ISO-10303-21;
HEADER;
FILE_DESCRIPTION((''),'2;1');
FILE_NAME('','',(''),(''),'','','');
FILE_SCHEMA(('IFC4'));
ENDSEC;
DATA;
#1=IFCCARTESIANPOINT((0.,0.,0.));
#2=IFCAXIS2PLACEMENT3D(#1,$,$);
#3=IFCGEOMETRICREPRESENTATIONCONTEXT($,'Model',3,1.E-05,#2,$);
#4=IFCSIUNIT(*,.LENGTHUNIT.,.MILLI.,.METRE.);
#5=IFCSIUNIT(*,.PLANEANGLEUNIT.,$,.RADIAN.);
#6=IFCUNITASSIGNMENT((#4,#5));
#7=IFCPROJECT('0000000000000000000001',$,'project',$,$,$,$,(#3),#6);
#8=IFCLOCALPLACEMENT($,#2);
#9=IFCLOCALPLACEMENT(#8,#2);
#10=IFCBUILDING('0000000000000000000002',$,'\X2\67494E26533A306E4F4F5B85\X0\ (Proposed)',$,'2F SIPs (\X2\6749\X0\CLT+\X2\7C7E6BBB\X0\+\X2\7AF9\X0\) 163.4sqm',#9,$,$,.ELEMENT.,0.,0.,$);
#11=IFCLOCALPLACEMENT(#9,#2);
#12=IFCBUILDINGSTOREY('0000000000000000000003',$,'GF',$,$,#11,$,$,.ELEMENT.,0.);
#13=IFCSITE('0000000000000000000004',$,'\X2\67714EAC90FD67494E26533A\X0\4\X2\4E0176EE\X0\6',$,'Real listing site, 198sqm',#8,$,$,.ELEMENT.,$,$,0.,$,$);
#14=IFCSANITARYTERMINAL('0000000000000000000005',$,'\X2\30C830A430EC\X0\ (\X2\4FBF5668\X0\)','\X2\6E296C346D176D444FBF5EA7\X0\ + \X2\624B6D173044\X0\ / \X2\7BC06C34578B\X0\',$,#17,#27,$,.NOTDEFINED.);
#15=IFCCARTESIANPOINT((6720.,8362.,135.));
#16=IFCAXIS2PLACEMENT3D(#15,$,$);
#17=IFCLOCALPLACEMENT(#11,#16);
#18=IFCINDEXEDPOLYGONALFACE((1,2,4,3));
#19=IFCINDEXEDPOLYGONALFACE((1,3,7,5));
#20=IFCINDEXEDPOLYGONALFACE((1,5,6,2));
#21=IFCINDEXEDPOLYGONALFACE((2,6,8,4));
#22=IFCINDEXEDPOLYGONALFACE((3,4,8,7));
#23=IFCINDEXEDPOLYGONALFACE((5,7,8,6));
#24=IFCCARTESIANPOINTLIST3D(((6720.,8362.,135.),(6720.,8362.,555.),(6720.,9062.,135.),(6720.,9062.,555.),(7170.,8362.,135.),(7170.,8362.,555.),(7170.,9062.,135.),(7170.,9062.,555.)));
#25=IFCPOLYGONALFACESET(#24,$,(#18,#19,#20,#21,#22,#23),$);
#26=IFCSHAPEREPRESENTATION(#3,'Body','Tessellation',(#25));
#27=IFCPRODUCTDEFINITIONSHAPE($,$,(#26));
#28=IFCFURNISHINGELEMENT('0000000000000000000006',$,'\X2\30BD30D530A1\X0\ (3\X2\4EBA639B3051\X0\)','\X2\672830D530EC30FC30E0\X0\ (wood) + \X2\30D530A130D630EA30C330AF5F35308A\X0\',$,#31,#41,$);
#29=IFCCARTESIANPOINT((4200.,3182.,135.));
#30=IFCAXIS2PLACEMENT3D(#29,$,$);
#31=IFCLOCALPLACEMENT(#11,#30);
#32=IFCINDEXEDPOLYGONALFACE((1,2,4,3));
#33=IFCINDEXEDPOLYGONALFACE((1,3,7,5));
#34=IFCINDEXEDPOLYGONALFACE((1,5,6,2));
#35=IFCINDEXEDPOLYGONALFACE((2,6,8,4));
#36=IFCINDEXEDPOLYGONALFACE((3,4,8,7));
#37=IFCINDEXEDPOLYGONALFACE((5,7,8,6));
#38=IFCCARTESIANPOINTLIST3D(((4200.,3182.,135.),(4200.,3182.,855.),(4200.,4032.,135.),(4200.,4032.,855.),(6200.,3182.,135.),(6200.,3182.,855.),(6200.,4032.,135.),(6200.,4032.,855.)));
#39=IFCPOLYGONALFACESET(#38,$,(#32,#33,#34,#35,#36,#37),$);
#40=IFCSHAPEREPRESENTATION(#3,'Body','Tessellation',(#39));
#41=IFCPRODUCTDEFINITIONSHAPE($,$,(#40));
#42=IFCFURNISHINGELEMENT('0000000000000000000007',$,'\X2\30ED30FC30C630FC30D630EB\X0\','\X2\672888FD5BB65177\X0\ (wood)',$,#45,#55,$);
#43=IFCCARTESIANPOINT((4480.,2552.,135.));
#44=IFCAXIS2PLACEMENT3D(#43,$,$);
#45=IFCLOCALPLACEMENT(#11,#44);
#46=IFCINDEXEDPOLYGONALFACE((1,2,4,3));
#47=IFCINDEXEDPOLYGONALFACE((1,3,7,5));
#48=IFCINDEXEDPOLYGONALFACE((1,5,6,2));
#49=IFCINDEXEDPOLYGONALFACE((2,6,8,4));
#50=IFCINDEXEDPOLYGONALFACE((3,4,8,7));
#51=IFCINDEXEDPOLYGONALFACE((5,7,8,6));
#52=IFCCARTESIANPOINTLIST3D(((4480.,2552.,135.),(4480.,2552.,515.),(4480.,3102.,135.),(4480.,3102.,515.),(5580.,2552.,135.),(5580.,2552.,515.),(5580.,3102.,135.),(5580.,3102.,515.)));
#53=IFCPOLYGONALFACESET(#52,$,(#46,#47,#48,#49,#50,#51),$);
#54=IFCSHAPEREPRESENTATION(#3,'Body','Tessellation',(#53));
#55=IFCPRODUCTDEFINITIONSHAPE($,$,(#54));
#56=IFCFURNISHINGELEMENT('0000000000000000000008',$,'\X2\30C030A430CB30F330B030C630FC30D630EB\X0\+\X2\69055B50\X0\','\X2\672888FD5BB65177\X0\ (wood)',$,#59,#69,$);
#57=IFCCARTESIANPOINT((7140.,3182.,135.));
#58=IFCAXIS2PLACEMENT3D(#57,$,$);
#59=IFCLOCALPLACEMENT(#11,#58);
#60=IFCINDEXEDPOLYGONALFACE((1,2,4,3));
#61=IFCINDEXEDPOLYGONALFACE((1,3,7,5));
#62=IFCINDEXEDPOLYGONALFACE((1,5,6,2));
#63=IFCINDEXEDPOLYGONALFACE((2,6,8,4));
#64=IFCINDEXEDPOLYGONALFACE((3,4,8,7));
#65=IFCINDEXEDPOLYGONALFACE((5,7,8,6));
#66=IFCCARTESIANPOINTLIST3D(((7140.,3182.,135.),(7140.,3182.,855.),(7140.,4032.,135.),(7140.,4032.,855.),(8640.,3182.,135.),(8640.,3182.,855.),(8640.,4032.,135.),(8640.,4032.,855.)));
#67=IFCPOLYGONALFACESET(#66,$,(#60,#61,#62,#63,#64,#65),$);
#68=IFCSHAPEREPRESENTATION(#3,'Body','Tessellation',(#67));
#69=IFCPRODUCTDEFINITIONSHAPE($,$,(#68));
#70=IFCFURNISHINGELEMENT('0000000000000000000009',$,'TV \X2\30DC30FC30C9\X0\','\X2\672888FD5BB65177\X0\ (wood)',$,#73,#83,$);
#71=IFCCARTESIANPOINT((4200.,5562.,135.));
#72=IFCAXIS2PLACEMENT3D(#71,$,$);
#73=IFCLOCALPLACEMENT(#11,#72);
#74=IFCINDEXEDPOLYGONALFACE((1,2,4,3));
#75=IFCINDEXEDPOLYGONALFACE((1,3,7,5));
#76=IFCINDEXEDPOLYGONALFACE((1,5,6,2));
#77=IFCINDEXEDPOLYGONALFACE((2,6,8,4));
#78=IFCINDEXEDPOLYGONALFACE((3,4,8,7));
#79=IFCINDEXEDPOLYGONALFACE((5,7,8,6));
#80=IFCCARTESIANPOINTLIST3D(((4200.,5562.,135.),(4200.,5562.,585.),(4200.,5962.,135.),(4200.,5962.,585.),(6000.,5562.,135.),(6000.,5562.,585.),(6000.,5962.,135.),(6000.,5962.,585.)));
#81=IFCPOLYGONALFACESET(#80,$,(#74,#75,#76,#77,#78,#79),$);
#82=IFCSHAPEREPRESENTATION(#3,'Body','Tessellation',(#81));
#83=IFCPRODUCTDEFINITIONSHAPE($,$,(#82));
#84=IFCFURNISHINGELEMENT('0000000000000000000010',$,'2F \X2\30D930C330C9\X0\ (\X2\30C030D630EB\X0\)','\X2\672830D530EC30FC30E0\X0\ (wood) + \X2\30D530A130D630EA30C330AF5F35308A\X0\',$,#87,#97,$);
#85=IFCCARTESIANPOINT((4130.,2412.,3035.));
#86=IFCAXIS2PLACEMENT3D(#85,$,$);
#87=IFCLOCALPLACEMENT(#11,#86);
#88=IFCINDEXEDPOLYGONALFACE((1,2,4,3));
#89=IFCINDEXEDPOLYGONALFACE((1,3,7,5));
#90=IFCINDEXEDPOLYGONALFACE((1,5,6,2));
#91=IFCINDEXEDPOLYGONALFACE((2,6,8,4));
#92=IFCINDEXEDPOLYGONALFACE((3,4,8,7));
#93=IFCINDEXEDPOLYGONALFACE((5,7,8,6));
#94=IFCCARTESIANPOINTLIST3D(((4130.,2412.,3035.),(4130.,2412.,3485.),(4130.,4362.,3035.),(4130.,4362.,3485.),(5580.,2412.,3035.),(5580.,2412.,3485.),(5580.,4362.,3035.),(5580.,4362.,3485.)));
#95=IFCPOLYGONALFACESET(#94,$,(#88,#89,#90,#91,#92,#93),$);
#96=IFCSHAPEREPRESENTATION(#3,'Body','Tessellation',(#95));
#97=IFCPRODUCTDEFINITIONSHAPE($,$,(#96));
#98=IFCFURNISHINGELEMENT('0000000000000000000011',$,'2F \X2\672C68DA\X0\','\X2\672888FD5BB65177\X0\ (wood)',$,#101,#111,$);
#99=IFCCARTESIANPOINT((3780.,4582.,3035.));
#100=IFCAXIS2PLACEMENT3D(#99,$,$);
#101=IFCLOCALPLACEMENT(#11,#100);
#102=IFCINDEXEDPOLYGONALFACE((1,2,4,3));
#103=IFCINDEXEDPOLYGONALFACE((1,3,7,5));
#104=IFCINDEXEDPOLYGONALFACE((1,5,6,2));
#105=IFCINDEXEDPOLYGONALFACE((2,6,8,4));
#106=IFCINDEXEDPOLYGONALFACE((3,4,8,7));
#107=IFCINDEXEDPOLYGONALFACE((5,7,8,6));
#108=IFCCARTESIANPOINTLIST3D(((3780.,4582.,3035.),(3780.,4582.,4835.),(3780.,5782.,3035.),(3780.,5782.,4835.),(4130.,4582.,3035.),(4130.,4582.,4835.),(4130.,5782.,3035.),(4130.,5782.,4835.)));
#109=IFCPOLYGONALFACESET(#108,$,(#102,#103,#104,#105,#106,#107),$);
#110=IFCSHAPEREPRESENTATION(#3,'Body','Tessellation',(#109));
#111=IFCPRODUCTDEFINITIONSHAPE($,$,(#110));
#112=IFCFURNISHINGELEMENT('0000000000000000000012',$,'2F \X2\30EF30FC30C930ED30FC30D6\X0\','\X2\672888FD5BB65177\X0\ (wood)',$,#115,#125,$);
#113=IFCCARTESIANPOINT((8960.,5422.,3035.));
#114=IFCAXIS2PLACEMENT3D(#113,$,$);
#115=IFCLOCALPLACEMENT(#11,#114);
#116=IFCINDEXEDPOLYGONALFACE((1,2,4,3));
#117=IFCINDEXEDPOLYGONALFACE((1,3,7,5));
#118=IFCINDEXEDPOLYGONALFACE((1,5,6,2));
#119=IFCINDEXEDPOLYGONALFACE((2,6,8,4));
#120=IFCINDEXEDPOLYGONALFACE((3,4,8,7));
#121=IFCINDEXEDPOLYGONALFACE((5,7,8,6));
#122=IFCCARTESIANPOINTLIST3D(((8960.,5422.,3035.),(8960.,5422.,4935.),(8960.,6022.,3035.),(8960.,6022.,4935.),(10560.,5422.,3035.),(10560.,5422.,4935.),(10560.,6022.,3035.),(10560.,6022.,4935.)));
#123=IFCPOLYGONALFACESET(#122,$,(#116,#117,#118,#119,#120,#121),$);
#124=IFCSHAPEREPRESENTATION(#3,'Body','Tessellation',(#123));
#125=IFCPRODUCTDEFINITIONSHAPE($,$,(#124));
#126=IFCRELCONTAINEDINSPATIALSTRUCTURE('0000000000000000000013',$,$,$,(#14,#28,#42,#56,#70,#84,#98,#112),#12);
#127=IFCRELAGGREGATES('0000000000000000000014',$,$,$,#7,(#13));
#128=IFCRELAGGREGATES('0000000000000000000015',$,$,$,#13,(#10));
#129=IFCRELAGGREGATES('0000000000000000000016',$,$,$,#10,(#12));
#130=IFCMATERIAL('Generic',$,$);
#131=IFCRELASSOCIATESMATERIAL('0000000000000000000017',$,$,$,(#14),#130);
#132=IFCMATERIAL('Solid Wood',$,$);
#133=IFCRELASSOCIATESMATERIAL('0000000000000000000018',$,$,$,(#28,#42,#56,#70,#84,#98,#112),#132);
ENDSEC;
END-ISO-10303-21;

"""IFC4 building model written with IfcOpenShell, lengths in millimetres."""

from ifc_helpers import new_model, si_unit, frame, frame_2d, origin, place, context, project, spatial, rectangle, extrude, material, element, save


model = new_model("IFC4")

# Units and contexts
model_context = context("Model", 3, precision=1e-05, world=origin())
ifc_project = project(units=[si_unit("LENGTHUNIT", "METRE", prefix="MILLI"), si_unit("PLANEANGLEUNIT", "RADIAN")], contexts=[model_context])

# Site, building, storey
site_placement = place(None, origin())
site = spatial("IfcSite", under=ifc_project, at=site_placement, Name="東京都杉並区4丁目6", ObjectType="Real listing site, 198sqm", CompositionType="ELEMENT", RefElevation=0.0)
building_placement = place(site_placement, origin())
building = spatial("IfcBuilding", under=site, at=building_placement, Name="杉並区の住宅 (Proposed)", ObjectType="2F SIPs (杉CLT+籾殻+竹) 163.4sqm", CompositionType="ELEMENT", ElevationOfRefHeight=0.0, ElevationOfTerrain=0.0)
storey_placement = place(building_placement, origin())
storey = spatial("IfcBuildingStorey", under=building, at=storey_placement, Name="GF", CompositionType="ELEMENT", Elevation=0.0)

# Shared definitions
ifc_material_1 = material(Name="Solid Wood")

# Shared definitions
ifc_material_2 = material(Name="Generic")

# Sanitary terminal
sanitary_terminal_1_placement = place(storey_placement, frame((6720.0, 8362.0, 135.0)))
element("IfcSanitaryTerminal", 1, at=sanitary_terminal_1_placement, inside=storey, material=ifc_material_2, Name="トイレ (便器)", Description="温水洗浄便座 + 手洗い / 節水型", PredefinedType="NOTDEFINED", context=model_context, shape_type="SweptSolid", body=[
    extrude(rectangle(XDim=450.0, YDim=700.0, at=frame_2d((225.0, 350.0))), frame((6720.0, 8362.0, 135.0)), (0.0, 0.0, 1.0), 420.0),
])

# Furnishing elements
furnishing_1_placement = place(storey_placement, frame((4200.0, 3182.0, 135.0)))
element("IfcFurnishingElement", 2, at=furnishing_1_placement, inside=storey, material=ifc_material_1, Name="ソファ (3人掛け)", Description="木フレーム (wood) + ファブリック張り", context=model_context, shape_type="SweptSolid", body=[
    extrude(rectangle(XDim=2000.0, YDim=850.0, at=frame_2d((1000.0, 425.0))), frame((4200.0, 3182.0, 135.0)), (0.0, 0.0, 1.0), 720.0),
])
furnishing_2_placement = place(storey_placement, frame((4480.0, 2552.0, 135.0)))
element("IfcFurnishingElement", 3, at=furnishing_2_placement, inside=storey, material=ifc_material_1, Name="ローテーブル", Description="木製家具 (wood)", context=model_context, shape_type="SweptSolid", body=[
    extrude(rectangle(XDim=1100.0, YDim=550.0, at=frame_2d((550.0, 275.0))), frame((4480.0, 2552.0, 135.0)), (0.0, 0.0, 1.0), 380.0),
])
furnishing_3_placement = place(storey_placement, frame((7140.0, 3182.0, 135.0)))
element("IfcFurnishingElement", 4, at=furnishing_3_placement, inside=storey, material=ifc_material_1, Name="ダイニングテーブル+椅子", Description="木製家具 (wood)", context=model_context, shape_type="SweptSolid", body=[
    extrude(rectangle(XDim=1500.0, YDim=850.0, at=frame_2d((750.0, 425.0))), frame((7140.0, 3182.0, 135.0)), (0.0, 0.0, 1.0), 720.0),
])
furnishing_4_placement = place(storey_placement, frame((4200.0, 5562.0, 135.0)))
element("IfcFurnishingElement", 5, at=furnishing_4_placement, inside=storey, material=ifc_material_1, Name="TV ボード", Description="木製家具 (wood)", context=model_context, shape_type="SweptSolid", body=[
    extrude(rectangle(XDim=1800.0, YDim=400.0, at=frame_2d((900.0, 200.0))), frame((4200.0, 5562.0, 135.0)), (0.0, 0.0, 1.0), 450.0),
])
furnishing_5_placement = place(storey_placement, frame((4130.0, 2412.0, 3035.0)))
element("IfcFurnishingElement", 6, at=furnishing_5_placement, inside=storey, material=ifc_material_1, Name="2F ベッド (ダブル)", Description="木フレーム (wood) + ファブリック張り", context=model_context, shape_type="SweptSolid", body=[
    extrude(rectangle(XDim=1450.0, YDim=1950.0, at=frame_2d((725.0, 975.0))), frame((4130.0, 2412.0, 3035.0)), (0.0, 0.0, 1.0), 450.0),
])
furnishing_6_placement = place(storey_placement, frame((3780.0, 4582.0, 3035.0)))
element("IfcFurnishingElement", 7, at=furnishing_6_placement, inside=storey, material=ifc_material_1, Name="2F 本棚", Description="木製家具 (wood)", context=model_context, shape_type="SweptSolid", body=[
    extrude(rectangle(XDim=350.0, YDim=1200.0, at=frame_2d((175.0, 600.0))), frame((3780.0, 4582.0, 3035.0)), (0.0, 0.0, 1.0), 1800.0),
])
furnishing_7_placement = place(storey_placement, frame((8960.0, 5422.0, 3035.0)))
element("IfcFurnishingElement", 8, at=furnishing_7_placement, inside=storey, material=ifc_material_1, Name="2F ワードローブ", Description="木製家具 (wood)", context=model_context, shape_type="SweptSolid", body=[
    extrude(rectangle(XDim=1600.0, YDim=600.0, at=frame_2d((800.0, 300.0))), frame((8960.0, 5422.0, 3035.0)), (0.0, 0.0, 1.0), 1900.0),
])

save(model, "model.ifc")
